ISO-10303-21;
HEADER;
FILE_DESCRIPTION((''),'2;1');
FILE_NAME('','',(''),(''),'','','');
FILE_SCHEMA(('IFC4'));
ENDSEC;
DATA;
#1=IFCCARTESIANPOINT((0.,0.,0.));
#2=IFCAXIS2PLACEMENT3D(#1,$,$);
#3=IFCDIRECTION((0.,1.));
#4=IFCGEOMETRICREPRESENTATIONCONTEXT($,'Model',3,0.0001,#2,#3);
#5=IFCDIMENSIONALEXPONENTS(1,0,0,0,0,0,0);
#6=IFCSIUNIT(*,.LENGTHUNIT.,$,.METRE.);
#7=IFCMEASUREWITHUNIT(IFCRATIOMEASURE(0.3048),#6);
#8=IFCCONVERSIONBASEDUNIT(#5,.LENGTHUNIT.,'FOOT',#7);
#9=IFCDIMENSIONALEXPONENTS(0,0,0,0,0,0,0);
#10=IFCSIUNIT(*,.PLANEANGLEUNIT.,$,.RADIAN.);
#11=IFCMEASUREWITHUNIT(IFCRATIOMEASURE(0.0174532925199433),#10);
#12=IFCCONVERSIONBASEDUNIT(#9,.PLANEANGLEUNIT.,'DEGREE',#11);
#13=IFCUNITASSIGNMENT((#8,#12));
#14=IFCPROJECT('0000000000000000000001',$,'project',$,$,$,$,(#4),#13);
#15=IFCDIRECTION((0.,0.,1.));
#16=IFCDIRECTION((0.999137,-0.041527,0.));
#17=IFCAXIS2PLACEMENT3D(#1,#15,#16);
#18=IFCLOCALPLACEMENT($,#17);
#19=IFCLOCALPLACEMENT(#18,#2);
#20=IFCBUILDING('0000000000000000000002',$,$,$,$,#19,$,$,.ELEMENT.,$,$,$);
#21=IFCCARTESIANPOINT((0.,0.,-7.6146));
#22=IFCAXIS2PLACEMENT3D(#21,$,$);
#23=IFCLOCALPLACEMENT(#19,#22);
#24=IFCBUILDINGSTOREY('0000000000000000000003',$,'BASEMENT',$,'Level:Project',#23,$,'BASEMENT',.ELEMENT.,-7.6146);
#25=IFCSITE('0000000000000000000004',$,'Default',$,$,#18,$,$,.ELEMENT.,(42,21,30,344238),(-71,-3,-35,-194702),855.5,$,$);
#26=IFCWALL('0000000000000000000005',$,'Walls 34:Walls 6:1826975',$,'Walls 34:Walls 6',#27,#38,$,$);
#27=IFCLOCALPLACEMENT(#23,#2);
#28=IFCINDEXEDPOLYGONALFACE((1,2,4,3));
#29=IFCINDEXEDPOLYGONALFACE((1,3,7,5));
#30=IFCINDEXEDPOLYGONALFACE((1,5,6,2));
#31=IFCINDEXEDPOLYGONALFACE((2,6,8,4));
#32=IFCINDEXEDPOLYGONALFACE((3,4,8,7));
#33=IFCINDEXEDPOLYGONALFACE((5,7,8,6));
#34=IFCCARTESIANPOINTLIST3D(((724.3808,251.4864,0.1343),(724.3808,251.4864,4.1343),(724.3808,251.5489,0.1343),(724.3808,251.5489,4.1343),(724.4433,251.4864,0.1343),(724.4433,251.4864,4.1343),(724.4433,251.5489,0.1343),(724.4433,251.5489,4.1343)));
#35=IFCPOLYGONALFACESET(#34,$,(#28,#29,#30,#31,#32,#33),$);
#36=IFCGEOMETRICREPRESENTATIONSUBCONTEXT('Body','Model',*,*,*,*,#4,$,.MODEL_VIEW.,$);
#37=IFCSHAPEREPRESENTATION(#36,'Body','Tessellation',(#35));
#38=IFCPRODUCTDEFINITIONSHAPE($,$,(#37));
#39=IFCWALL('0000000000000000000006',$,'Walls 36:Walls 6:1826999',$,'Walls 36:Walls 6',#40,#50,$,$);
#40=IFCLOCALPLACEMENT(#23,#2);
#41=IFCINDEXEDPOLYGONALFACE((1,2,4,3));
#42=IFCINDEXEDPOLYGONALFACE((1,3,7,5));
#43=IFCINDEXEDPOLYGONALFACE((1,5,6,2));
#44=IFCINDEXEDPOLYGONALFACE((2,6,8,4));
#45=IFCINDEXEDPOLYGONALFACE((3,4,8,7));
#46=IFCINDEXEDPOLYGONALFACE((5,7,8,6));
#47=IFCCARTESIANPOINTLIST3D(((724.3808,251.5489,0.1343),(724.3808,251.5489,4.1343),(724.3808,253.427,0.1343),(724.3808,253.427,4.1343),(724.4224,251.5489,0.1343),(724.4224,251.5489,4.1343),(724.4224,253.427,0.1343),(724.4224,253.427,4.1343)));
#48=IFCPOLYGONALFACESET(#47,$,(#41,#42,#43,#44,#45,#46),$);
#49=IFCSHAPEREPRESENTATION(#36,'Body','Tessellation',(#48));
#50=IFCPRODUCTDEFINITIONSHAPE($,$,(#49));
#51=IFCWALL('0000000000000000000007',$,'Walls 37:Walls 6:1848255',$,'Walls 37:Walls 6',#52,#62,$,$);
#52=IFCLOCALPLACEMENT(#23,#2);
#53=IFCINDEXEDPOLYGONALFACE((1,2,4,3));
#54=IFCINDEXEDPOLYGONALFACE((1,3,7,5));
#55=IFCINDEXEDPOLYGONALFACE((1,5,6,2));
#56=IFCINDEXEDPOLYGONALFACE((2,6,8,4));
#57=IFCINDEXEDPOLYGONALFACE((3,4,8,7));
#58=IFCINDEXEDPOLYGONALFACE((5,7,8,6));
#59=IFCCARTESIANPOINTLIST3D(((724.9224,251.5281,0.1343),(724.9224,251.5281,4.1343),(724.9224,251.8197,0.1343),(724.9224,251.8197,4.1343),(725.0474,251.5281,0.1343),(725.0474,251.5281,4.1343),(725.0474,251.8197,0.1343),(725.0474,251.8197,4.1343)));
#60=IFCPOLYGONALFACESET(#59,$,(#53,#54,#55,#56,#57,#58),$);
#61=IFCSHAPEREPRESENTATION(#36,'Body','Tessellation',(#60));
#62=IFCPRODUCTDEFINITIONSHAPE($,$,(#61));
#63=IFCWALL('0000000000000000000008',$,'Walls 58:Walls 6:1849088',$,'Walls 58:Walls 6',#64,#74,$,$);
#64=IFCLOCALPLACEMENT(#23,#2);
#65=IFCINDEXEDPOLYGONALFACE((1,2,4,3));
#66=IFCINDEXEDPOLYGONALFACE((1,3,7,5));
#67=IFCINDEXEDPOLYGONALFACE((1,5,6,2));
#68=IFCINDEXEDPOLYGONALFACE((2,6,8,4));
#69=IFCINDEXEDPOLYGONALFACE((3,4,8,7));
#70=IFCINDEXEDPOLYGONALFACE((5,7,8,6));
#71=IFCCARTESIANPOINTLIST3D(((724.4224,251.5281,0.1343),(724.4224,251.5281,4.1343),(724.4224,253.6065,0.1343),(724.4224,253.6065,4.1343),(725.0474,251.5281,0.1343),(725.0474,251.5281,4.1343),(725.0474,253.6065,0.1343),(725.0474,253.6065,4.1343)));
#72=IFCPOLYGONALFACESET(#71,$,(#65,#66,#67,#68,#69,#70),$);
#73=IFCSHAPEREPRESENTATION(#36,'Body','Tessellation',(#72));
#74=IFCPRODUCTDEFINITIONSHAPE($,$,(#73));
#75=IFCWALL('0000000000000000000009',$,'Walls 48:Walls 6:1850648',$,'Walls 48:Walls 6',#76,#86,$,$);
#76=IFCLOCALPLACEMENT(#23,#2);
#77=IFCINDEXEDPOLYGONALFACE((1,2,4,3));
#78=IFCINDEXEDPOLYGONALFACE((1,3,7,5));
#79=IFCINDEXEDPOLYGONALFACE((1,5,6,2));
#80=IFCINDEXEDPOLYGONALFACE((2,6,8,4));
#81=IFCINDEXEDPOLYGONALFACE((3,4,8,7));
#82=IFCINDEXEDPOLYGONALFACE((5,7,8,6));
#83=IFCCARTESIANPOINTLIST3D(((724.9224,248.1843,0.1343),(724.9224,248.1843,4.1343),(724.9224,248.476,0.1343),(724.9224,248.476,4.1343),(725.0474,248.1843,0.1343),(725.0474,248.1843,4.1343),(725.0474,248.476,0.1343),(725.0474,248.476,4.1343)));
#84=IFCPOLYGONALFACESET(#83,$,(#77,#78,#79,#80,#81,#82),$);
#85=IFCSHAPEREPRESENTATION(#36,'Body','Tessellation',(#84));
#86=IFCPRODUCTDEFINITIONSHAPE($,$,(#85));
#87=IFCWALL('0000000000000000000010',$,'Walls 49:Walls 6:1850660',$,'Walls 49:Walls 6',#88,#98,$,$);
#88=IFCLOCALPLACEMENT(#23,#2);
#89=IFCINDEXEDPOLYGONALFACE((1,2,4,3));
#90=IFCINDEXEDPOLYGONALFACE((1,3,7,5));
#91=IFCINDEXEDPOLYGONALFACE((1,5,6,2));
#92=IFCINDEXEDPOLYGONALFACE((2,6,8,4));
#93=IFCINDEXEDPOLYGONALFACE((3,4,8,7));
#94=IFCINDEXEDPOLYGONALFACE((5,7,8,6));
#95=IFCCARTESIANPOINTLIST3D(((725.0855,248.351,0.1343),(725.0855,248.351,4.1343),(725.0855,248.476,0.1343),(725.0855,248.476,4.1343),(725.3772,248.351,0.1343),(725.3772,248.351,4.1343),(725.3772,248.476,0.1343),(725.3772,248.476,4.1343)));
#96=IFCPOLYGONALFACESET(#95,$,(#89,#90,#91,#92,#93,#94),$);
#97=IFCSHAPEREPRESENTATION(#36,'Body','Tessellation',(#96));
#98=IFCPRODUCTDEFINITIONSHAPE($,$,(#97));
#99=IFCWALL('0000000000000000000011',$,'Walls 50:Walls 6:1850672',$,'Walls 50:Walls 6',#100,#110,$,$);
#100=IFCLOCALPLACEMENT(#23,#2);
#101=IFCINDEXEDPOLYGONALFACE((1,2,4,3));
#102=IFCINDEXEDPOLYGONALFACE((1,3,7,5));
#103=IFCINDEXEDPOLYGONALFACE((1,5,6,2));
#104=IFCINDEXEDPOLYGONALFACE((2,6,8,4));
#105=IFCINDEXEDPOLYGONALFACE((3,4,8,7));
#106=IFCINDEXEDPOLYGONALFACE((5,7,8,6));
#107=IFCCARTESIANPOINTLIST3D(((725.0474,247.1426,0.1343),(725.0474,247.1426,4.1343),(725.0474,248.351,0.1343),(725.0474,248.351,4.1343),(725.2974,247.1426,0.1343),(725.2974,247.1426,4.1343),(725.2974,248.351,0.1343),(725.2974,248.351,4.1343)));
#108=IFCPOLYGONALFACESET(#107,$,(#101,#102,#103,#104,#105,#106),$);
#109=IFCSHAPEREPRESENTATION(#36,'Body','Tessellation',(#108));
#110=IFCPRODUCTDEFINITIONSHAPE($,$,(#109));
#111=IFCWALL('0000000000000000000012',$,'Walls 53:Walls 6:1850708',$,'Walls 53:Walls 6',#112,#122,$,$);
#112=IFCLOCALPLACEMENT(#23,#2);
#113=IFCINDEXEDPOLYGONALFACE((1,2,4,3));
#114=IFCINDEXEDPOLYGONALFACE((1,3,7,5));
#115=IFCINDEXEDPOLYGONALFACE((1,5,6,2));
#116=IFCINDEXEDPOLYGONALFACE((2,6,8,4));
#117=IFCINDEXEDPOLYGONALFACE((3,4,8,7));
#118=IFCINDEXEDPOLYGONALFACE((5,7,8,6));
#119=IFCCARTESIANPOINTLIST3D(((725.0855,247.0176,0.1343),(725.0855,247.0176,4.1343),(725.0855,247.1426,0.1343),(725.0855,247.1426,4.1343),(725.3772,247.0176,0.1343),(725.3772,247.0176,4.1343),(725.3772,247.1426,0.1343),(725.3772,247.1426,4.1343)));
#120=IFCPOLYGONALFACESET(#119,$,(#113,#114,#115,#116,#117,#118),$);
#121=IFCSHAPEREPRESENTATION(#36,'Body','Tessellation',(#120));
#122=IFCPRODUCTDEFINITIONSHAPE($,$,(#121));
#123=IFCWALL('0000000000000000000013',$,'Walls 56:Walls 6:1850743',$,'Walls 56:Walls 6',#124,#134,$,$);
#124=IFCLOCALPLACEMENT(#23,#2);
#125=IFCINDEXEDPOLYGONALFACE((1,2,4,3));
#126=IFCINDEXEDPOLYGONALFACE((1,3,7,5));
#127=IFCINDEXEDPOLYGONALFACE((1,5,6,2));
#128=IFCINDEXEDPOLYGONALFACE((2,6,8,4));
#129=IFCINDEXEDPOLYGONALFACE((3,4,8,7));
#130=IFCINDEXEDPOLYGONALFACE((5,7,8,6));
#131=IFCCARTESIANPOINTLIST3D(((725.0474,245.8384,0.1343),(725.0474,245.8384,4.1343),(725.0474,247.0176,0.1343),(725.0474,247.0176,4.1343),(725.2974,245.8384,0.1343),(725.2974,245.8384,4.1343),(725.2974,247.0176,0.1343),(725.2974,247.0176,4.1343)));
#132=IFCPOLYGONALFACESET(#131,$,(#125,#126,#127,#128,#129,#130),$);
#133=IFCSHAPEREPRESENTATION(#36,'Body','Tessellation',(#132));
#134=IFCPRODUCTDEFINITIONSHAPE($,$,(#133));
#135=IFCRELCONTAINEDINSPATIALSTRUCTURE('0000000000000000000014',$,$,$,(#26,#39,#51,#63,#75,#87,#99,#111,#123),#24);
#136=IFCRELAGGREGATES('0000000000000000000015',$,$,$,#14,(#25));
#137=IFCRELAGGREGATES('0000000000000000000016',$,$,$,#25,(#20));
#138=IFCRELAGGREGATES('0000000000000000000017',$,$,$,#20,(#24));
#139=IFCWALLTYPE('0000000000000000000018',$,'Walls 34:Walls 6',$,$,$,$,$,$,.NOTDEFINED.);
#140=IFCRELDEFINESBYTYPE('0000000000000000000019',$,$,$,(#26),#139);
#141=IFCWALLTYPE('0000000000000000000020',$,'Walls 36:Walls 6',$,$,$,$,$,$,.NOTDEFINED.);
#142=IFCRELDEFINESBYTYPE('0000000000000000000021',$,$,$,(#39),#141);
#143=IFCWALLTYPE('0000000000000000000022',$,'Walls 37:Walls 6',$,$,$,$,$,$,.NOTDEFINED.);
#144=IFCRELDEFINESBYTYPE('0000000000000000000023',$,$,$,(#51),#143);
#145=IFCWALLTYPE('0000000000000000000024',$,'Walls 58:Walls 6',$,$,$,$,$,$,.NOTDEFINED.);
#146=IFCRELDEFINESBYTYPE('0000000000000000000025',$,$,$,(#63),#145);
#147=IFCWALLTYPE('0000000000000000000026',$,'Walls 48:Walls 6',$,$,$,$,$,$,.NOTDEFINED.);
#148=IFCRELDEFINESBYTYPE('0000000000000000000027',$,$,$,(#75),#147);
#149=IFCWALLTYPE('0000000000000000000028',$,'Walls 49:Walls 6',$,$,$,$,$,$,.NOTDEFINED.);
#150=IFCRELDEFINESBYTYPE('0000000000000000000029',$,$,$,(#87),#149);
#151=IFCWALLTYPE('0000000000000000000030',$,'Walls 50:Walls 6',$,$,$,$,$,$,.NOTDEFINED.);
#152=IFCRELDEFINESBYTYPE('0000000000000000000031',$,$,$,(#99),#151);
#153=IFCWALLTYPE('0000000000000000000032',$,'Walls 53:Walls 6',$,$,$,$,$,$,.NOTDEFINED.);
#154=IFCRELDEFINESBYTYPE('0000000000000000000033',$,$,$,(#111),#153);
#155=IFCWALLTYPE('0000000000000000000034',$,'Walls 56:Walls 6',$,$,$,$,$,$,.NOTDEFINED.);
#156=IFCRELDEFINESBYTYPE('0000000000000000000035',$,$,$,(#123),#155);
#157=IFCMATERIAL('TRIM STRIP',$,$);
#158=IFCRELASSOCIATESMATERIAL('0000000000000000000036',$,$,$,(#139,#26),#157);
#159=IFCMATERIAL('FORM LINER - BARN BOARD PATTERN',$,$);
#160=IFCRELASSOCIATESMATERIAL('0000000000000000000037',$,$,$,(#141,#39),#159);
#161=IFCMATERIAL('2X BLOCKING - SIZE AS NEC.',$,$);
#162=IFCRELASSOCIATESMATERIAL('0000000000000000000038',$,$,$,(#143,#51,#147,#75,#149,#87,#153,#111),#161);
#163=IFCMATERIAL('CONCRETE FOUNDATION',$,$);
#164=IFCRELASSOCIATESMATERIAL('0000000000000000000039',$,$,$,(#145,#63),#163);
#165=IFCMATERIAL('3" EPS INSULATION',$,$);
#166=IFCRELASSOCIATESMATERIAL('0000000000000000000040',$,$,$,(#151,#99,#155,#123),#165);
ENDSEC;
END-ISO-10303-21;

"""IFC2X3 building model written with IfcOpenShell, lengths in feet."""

from ifc_helpers import new_model, entity, si_unit, converted_unit, direction, frame, frame_2d, origin, origin_2d_with_axis, place, context, subcontext, project, spatial, rectangle, extrude, material, type_object, element, save


model = new_model("IFC2X3")

# Units and contexts
model_context = context("Model", 3, precision=0.0001, world=origin(), true_north=direction((0.0, 1.0)))
body_context = subcontext(model_context, "Body", "Model", "MODEL_VIEW")
ifc_project = project(units=[converted_unit("LENGTHUNIT", "FOOT", entity("IfcRatioMeasure", 0.3048), si_unit("LENGTHUNIT", "METRE"), dimensions=[1, 0, 0, 0, 0, 0, 0]), converted_unit("PLANEANGLEUNIT", "DEGREE", entity("IfcRatioMeasure", 0.0174532925199433), si_unit("PLANEANGLEUNIT", "RADIAN"), dimensions=[0, 0, 0, 0, 0, 0, 0])], contexts=[model_context])

# Site, building, storey
site_placement = place(None, frame((0.0, 0.0, 0.0), z_axis=(0.0, 0.0, 1.0), x_axis=(0.999137, -0.041527, 0.0)))
site = spatial("IfcSite", under=ifc_project, at=site_placement, Name="Default", CompositionType="ELEMENT", RefLatitude=(42, 21, 30, 344238), RefLongitude=(-71, -3, -35, -194702), RefElevation=855.5)
building_placement = place(site_placement, origin())
building = spatial("IfcBuilding", under=site, at=building_placement, CompositionType="ELEMENT")
storey_placement = place(building_placement, frame((0.0, 0.0, -7.6146)))
storey = spatial("IfcBuildingStorey", under=building, at=storey_placement, Name="BASEMENT", ObjectType="Level:Project", LongName="BASEMENT", CompositionType="ELEMENT", Elevation=-7.6146)

# Walls
ifc_material_1 = material(Name="FORM LINER - BARN BOARD PATTERN")
ifc_material_2 = material(Name="TRIM STRIP")
wall_type_1 = type_object("IfcWallType", Name="Walls 34:Walls 6", PredefinedType="NOTDEFINED", material=ifc_material_2)
wall_1_placement = place(storey_placement, frame((724.3808, 251.4864, 0.1343)))
element("IfcWall", 1, at=wall_1_placement, inside=storey, type_object=wall_type_1, material=ifc_material_2, Name="Walls 34:Walls 6:1826975", ObjectType="Walls 34:Walls 6", context=body_context, shape_type="SweptSolid", body=[
    extrude(rectangle(XDim=0.0625, YDim=0.0625, at=origin_2d_with_axis()), frame((0.0312, 0.0312, 0.0), z_axis=(0.0, 0.0, 1.0), x_axis=(0.0, 1.0, 0.0)), (0.0, 0.0, 1.0), 4.0),
])
wall_type_2 = type_object("IfcWallType", Name="Walls 36:Walls 6", PredefinedType="NOTDEFINED", material=ifc_material_1)
wall_2_placement = place(storey_placement, frame((724.3808, 251.5489, 0.1343), z_axis=(0.0, 0.0, 1.0), x_axis=(0.0, 1.0, 0.0)))
element("IfcWall", 2, at=wall_2_placement, inside=storey, type_object=wall_type_2, material=ifc_material_1, Name="Walls 36:Walls 6:1826999", ObjectType="Walls 36:Walls 6", context=body_context, shape_type="SweptSolid", body=[
    extrude(rectangle(XDim=1.8781, YDim=0.0417, at=frame_2d((0.0, 0.0), x_axis=(1.0, 0.0))), frame((0.939, -0.0208, 0.0)), (0.0, 0.0, 1.0), 4.0),
])
ifc_material_3 = material(Name="2X BLOCKING - SIZE AS NEC.")
wall_type_3 = type_object("IfcWallType", Name="Walls 37:Walls 6", PredefinedType="NOTDEFINED", material=ifc_material_3)
wall_3_placement = place(storey_placement, frame((724.9224, 251.5281, 0.1343), z_axis=(0.0, 0.0, 1.0), x_axis=(0.0, 1.0, 0.0)))
element("IfcWall", 3, at=wall_3_placement, inside=storey, type_object=wall_type_3, material=ifc_material_3, Name="Walls 37:Walls 6:1848255", ObjectType="Walls 37:Walls 6", context=body_context, shape_type="SweptSolid", body=[
    extrude(rectangle(XDim=0.2917, YDim=0.125, at=frame_2d((0.0, 0.0), x_axis=(1.0, 0.0))), frame((0.1458, -0.0625, 0.0), z_axis=(0.0, 0.0, 1.0), x_axis=(-1.0, 0.0, 0.0)), (0.0, 0.0, 1.0), 4.0),
])
ifc_material_4 = material(Name="CONCRETE FOUNDATION")
wall_type_4 = type_object("IfcWallType", Name="Walls 58:Walls 6", PredefinedType="NOTDEFINED", material=ifc_material_4)
wall_4_placement = place(storey_placement, frame((724.4224, 251.5281, 0.1343), z_axis=(0.0, 0.0, 1.0), x_axis=(0.0, 1.0, 0.0)))
element("IfcWall", 4, at=wall_4_placement, inside=storey, type_object=wall_type_4, material=ifc_material_4, Name="Walls 58:Walls 6:1849088", ObjectType="Walls 58:Walls 6", context=body_context, shape_type="SweptSolid", body=[
    extrude(rectangle(XDim=0.625, YDim=2.0784, at=frame_2d((0.0, 0.0), x_axis=(1.0, 0.0))), frame((1.0392, -0.3125, 0.0), z_axis=(0.0, 0.0, 1.0), x_axis=(0.0, -1.0, 0.0)), (0.0, 0.0, 1.0), 4.0),
])
wall_type_5 = type_object("IfcWallType", Name="Walls 48:Walls 6", PredefinedType="NOTDEFINED", material=ifc_material_3)
wall_5_placement = place(storey_placement, frame((724.9224, 248.1843, 0.1343), z_axis=(0.0, 0.0, 1.0), x_axis=(0.0, 1.0, 0.0)))
element("IfcWall", 5, at=wall_5_placement, inside=storey, type_object=wall_type_5, material=ifc_material_3, Name="Walls 48:Walls 6:1850648", ObjectType="Walls 48:Walls 6", context=body_context, shape_type="SweptSolid", body=[
    extrude(rectangle(XDim=0.125, YDim=0.2917, at=frame_2d((0.0, 0.0), x_axis=(1.0, 0.0))), frame((0.1458, -0.0625, 0.0), z_axis=(0.0, 0.0, 1.0), x_axis=(0.0, -1.0, 0.0)), (0.0, 0.0, 1.0), 4.0),
])
wall_type_6 = type_object("IfcWallType", Name="Walls 49:Walls 6", PredefinedType="NOTDEFINED", material=ifc_material_3)
wall_6_placement = place(storey_placement, frame((725.0855, 248.351, 0.1343)))
element("IfcWall", 6, at=wall_6_placement, inside=storey, type_object=wall_type_6, material=ifc_material_3, Name="Walls 49:Walls 6:1850660", ObjectType="Walls 49:Walls 6", context=body_context, shape_type="SweptSolid", body=[
    extrude(rectangle(XDim=0.125, YDim=0.2917, at=frame_2d((0.0, 0.0), x_axis=(1.0, 0.0))), frame((0.1458, 0.0625, 0.0), z_axis=(0.0, 0.0, 1.0), x_axis=(0.0, -1.0, 0.0)), (0.0, 0.0, 1.0), 4.0),
])
ifc_material_5 = material(Name="3\" EPS INSULATION")
wall_type_7 = type_object("IfcWallType", Name="Walls 50:Walls 6", PredefinedType="NOTDEFINED", material=ifc_material_5)
wall_7_placement = place(storey_placement, frame((725.0474, 247.1426, 0.1343), z_axis=(0.0, 0.0, 1.0), x_axis=(0.0, 1.0, 0.0)))
element("IfcWall", 7, at=wall_7_placement, inside=storey, type_object=wall_type_7, material=ifc_material_5, Name="Walls 50:Walls 6:1850672", ObjectType="Walls 50:Walls 6", context=body_context, shape_type="SweptSolid", body=[
    extrude(rectangle(XDim=1.2083, YDim=0.25, at=frame_2d((0.0, 0.0), x_axis=(1.0, 0.0))), frame((0.6042, -0.125, 0.0), z_axis=(0.0, 0.0, 1.0), x_axis=(-1.0, 0.0, 0.0)), (0.0, 0.0, 1.0), 4.0),
])
wall_type_8 = type_object("IfcWallType", Name="Walls 53:Walls 6", PredefinedType="NOTDEFINED", material=ifc_material_3)
wall_8_placement = place(storey_placement, frame((725.0855, 247.0176, 0.1343)))
element("IfcWall", 8, at=wall_8_placement, inside=storey, type_object=wall_type_8, material=ifc_material_3, Name="Walls 53:Walls 6:1850708", ObjectType="Walls 53:Walls 6", context=body_context, shape_type="SweptSolid", body=[
    extrude(rectangle(XDim=0.125, YDim=0.2917, at=frame_2d((0.0, 0.0), x_axis=(1.0, 0.0))), frame((0.1458, 0.0625, 0.0), z_axis=(0.0, 0.0, 1.0), x_axis=(0.0, -1.0, 0.0)), (0.0, 0.0, 1.0), 4.0),
])
wall_type_9 = type_object("IfcWallType", Name="Walls 56:Walls 6", PredefinedType="NOTDEFINED", material=ifc_material_5)
wall_9_placement = place(storey_placement, frame((725.0474, 245.8384, 0.1343), z_axis=(0.0, 0.0, 1.0), x_axis=(0.0, 1.0, 0.0)))
element("IfcWall", 9, at=wall_9_placement, inside=storey, type_object=wall_type_9, material=ifc_material_5, Name="Walls 56:Walls 6:1850743", ObjectType="Walls 56:Walls 6", context=body_context, shape_type="SweptSolid", body=[
    extrude(rectangle(XDim=1.1792, YDim=0.25, at=frame_2d((0.0, 0.0), x_axis=(1.0, 0.0))), frame((0.5896, -0.125, 0.0), z_axis=(0.0, 0.0, 1.0), x_axis=(-1.0, 0.0, 0.0)), (0.0, 0.0, 1.0), 4.0),
])

save(model, "model.ifc")
